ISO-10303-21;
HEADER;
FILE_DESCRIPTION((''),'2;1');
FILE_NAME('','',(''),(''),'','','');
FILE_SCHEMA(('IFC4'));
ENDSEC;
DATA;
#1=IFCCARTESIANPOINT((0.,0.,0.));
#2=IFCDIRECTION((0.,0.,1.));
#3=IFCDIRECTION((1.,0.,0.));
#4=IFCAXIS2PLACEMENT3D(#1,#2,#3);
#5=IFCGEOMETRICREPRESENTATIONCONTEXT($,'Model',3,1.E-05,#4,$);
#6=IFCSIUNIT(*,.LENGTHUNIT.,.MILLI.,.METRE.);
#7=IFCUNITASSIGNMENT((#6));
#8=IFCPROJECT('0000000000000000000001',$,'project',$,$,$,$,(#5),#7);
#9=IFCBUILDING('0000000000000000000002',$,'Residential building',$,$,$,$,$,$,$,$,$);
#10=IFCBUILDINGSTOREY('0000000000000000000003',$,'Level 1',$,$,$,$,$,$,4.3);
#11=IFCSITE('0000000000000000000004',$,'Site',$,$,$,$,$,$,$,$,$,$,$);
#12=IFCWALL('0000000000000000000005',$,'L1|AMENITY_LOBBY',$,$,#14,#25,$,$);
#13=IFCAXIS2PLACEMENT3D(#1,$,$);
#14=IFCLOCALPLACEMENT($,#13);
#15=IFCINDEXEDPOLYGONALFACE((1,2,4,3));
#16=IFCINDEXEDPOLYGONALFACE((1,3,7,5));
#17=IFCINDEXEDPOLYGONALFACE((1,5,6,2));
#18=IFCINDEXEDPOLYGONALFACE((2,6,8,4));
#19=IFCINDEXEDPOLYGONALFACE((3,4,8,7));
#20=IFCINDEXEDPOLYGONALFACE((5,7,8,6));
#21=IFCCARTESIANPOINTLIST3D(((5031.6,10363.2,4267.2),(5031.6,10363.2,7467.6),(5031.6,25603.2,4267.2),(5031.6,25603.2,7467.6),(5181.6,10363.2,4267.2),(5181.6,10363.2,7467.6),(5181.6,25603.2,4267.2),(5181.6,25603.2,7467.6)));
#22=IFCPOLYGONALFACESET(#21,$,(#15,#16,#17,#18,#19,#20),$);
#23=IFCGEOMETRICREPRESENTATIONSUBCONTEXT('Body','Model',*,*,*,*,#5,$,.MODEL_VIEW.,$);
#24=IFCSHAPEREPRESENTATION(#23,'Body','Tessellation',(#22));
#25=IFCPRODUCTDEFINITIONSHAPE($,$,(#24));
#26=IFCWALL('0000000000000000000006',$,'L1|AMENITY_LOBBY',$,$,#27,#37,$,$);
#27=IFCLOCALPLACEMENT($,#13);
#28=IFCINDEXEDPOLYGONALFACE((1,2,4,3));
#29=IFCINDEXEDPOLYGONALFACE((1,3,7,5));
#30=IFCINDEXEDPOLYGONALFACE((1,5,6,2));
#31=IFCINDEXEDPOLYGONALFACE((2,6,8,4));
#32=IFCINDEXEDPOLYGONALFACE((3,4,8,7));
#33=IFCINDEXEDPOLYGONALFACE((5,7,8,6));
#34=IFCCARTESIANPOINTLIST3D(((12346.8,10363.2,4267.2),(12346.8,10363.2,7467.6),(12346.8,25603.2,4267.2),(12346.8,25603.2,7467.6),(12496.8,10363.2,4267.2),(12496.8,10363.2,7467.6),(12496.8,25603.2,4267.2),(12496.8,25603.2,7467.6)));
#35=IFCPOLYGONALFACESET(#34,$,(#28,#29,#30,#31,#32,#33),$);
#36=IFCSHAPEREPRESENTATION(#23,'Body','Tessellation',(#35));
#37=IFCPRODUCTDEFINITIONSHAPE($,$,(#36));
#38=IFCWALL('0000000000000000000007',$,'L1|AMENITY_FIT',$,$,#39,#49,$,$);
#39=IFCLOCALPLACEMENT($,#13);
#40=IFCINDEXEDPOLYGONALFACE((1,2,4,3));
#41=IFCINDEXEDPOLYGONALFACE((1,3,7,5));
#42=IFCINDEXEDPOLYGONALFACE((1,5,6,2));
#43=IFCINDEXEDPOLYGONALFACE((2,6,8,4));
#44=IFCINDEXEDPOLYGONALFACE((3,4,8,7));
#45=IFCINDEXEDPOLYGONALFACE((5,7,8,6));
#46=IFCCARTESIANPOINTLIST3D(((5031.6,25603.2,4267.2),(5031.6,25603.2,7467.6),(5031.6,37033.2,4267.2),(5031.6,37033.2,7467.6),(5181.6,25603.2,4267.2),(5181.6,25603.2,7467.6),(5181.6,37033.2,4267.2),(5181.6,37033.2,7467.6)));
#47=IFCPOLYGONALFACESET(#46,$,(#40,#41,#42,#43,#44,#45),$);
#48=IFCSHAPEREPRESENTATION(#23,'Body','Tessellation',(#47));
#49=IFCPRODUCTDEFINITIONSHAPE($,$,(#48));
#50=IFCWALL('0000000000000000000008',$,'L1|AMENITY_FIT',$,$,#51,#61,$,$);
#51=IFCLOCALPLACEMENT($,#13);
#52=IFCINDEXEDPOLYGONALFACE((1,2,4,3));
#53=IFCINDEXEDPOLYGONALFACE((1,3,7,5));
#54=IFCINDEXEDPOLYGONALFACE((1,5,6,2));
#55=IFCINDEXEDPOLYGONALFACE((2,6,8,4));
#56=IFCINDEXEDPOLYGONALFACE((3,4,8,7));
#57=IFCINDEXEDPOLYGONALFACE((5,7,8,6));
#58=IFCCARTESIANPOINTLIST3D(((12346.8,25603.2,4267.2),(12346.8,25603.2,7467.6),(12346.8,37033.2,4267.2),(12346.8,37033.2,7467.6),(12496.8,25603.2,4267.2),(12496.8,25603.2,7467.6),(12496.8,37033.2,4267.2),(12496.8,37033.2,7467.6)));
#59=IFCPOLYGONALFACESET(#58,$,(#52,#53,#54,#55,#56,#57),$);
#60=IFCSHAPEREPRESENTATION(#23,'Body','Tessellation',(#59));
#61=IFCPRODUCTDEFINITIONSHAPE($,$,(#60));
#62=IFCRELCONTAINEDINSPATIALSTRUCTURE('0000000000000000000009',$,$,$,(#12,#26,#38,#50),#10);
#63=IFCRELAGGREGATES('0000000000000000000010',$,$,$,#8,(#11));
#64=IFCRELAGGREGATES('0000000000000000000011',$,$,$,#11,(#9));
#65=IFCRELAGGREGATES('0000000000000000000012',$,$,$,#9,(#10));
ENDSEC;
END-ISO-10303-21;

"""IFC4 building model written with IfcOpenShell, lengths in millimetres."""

from ifc_helpers import new_model, si_unit, frame, origin_with_axes, place, context, subcontext, project, spatial, indexed_curve, outline, extrude, element, save


model = new_model("IFC4")

# Units and contexts
model_context = context("Model", 3, precision=1e-05, world=origin_with_axes())
body_context = subcontext(model_context, "Body", "Model", "MODEL_VIEW")
ifc_project = project(units=[si_unit("LENGTHUNIT", "METRE", prefix="MILLI")], contexts=[model_context])

# Site, building, storey
site = spatial("IfcSite", under=ifc_project, Name="Site")
building = spatial("IfcBuilding", under=site, Name="Residential building")
storey = spatial("IfcBuildingStorey", under=building, Name="Level 1", Elevation=4.3)

# Walls
for number, where, z_axis, x_axis, name in (
    (1, (5181.6, 10363.2, 4267.2), (0.0, 0.0, 1.0), (0.0, 1.0, 0.0), "L1|AMENITY_LOBBY"),
    (2, (12496.8, 10363.2, 4267.2), (0.0, 0.0, 1.0), (0.0, 1.0, 0.0), "L1|AMENITY_LOBBY"),
):
    element("IfcWall", number, at=place(None, frame(where, z_axis=z_axis, x_axis=x_axis)), inside=storey, Name=name, context=body_context, shape_type="SweptSolid", body=[
        extrude(outline(indexed_curve([(0.0, 0.0), (0.0, 150.0), (15240.0, 150.0), (15240.0, 0.0), (0.0, 0.0)], self_intersect=False)), origin_with_axes(), (0.0, 0.0, 1.0), 3200.4),
    ])
for number, where, z_axis, x_axis, name in (
    (3, (5181.6, 25603.2, 4267.2), (0.0, 0.0, 1.0), (0.0, 1.0, 0.0), "L1|AMENITY_FIT"),
    (4, (12496.8, 25603.2, 4267.2), (0.0, 0.0, 1.0), (0.0, 1.0, 0.0), "L1|AMENITY_FIT"),
):
    element("IfcWall", number, at=place(None, frame(where, z_axis=z_axis, x_axis=x_axis)), inside=storey, Name=name, context=body_context, shape_type="SweptSolid", body=[
        extrude(outline(indexed_curve([(0.0, 0.0), (0.0, 150.0), (11430.0, 150.0), (11430.0, 0.0), (0.0, 0.0)], self_intersect=False)), origin_with_axes(), (0.0, 0.0, 1.0), 3200.4),
    ])

save(model, "model.ifc")
